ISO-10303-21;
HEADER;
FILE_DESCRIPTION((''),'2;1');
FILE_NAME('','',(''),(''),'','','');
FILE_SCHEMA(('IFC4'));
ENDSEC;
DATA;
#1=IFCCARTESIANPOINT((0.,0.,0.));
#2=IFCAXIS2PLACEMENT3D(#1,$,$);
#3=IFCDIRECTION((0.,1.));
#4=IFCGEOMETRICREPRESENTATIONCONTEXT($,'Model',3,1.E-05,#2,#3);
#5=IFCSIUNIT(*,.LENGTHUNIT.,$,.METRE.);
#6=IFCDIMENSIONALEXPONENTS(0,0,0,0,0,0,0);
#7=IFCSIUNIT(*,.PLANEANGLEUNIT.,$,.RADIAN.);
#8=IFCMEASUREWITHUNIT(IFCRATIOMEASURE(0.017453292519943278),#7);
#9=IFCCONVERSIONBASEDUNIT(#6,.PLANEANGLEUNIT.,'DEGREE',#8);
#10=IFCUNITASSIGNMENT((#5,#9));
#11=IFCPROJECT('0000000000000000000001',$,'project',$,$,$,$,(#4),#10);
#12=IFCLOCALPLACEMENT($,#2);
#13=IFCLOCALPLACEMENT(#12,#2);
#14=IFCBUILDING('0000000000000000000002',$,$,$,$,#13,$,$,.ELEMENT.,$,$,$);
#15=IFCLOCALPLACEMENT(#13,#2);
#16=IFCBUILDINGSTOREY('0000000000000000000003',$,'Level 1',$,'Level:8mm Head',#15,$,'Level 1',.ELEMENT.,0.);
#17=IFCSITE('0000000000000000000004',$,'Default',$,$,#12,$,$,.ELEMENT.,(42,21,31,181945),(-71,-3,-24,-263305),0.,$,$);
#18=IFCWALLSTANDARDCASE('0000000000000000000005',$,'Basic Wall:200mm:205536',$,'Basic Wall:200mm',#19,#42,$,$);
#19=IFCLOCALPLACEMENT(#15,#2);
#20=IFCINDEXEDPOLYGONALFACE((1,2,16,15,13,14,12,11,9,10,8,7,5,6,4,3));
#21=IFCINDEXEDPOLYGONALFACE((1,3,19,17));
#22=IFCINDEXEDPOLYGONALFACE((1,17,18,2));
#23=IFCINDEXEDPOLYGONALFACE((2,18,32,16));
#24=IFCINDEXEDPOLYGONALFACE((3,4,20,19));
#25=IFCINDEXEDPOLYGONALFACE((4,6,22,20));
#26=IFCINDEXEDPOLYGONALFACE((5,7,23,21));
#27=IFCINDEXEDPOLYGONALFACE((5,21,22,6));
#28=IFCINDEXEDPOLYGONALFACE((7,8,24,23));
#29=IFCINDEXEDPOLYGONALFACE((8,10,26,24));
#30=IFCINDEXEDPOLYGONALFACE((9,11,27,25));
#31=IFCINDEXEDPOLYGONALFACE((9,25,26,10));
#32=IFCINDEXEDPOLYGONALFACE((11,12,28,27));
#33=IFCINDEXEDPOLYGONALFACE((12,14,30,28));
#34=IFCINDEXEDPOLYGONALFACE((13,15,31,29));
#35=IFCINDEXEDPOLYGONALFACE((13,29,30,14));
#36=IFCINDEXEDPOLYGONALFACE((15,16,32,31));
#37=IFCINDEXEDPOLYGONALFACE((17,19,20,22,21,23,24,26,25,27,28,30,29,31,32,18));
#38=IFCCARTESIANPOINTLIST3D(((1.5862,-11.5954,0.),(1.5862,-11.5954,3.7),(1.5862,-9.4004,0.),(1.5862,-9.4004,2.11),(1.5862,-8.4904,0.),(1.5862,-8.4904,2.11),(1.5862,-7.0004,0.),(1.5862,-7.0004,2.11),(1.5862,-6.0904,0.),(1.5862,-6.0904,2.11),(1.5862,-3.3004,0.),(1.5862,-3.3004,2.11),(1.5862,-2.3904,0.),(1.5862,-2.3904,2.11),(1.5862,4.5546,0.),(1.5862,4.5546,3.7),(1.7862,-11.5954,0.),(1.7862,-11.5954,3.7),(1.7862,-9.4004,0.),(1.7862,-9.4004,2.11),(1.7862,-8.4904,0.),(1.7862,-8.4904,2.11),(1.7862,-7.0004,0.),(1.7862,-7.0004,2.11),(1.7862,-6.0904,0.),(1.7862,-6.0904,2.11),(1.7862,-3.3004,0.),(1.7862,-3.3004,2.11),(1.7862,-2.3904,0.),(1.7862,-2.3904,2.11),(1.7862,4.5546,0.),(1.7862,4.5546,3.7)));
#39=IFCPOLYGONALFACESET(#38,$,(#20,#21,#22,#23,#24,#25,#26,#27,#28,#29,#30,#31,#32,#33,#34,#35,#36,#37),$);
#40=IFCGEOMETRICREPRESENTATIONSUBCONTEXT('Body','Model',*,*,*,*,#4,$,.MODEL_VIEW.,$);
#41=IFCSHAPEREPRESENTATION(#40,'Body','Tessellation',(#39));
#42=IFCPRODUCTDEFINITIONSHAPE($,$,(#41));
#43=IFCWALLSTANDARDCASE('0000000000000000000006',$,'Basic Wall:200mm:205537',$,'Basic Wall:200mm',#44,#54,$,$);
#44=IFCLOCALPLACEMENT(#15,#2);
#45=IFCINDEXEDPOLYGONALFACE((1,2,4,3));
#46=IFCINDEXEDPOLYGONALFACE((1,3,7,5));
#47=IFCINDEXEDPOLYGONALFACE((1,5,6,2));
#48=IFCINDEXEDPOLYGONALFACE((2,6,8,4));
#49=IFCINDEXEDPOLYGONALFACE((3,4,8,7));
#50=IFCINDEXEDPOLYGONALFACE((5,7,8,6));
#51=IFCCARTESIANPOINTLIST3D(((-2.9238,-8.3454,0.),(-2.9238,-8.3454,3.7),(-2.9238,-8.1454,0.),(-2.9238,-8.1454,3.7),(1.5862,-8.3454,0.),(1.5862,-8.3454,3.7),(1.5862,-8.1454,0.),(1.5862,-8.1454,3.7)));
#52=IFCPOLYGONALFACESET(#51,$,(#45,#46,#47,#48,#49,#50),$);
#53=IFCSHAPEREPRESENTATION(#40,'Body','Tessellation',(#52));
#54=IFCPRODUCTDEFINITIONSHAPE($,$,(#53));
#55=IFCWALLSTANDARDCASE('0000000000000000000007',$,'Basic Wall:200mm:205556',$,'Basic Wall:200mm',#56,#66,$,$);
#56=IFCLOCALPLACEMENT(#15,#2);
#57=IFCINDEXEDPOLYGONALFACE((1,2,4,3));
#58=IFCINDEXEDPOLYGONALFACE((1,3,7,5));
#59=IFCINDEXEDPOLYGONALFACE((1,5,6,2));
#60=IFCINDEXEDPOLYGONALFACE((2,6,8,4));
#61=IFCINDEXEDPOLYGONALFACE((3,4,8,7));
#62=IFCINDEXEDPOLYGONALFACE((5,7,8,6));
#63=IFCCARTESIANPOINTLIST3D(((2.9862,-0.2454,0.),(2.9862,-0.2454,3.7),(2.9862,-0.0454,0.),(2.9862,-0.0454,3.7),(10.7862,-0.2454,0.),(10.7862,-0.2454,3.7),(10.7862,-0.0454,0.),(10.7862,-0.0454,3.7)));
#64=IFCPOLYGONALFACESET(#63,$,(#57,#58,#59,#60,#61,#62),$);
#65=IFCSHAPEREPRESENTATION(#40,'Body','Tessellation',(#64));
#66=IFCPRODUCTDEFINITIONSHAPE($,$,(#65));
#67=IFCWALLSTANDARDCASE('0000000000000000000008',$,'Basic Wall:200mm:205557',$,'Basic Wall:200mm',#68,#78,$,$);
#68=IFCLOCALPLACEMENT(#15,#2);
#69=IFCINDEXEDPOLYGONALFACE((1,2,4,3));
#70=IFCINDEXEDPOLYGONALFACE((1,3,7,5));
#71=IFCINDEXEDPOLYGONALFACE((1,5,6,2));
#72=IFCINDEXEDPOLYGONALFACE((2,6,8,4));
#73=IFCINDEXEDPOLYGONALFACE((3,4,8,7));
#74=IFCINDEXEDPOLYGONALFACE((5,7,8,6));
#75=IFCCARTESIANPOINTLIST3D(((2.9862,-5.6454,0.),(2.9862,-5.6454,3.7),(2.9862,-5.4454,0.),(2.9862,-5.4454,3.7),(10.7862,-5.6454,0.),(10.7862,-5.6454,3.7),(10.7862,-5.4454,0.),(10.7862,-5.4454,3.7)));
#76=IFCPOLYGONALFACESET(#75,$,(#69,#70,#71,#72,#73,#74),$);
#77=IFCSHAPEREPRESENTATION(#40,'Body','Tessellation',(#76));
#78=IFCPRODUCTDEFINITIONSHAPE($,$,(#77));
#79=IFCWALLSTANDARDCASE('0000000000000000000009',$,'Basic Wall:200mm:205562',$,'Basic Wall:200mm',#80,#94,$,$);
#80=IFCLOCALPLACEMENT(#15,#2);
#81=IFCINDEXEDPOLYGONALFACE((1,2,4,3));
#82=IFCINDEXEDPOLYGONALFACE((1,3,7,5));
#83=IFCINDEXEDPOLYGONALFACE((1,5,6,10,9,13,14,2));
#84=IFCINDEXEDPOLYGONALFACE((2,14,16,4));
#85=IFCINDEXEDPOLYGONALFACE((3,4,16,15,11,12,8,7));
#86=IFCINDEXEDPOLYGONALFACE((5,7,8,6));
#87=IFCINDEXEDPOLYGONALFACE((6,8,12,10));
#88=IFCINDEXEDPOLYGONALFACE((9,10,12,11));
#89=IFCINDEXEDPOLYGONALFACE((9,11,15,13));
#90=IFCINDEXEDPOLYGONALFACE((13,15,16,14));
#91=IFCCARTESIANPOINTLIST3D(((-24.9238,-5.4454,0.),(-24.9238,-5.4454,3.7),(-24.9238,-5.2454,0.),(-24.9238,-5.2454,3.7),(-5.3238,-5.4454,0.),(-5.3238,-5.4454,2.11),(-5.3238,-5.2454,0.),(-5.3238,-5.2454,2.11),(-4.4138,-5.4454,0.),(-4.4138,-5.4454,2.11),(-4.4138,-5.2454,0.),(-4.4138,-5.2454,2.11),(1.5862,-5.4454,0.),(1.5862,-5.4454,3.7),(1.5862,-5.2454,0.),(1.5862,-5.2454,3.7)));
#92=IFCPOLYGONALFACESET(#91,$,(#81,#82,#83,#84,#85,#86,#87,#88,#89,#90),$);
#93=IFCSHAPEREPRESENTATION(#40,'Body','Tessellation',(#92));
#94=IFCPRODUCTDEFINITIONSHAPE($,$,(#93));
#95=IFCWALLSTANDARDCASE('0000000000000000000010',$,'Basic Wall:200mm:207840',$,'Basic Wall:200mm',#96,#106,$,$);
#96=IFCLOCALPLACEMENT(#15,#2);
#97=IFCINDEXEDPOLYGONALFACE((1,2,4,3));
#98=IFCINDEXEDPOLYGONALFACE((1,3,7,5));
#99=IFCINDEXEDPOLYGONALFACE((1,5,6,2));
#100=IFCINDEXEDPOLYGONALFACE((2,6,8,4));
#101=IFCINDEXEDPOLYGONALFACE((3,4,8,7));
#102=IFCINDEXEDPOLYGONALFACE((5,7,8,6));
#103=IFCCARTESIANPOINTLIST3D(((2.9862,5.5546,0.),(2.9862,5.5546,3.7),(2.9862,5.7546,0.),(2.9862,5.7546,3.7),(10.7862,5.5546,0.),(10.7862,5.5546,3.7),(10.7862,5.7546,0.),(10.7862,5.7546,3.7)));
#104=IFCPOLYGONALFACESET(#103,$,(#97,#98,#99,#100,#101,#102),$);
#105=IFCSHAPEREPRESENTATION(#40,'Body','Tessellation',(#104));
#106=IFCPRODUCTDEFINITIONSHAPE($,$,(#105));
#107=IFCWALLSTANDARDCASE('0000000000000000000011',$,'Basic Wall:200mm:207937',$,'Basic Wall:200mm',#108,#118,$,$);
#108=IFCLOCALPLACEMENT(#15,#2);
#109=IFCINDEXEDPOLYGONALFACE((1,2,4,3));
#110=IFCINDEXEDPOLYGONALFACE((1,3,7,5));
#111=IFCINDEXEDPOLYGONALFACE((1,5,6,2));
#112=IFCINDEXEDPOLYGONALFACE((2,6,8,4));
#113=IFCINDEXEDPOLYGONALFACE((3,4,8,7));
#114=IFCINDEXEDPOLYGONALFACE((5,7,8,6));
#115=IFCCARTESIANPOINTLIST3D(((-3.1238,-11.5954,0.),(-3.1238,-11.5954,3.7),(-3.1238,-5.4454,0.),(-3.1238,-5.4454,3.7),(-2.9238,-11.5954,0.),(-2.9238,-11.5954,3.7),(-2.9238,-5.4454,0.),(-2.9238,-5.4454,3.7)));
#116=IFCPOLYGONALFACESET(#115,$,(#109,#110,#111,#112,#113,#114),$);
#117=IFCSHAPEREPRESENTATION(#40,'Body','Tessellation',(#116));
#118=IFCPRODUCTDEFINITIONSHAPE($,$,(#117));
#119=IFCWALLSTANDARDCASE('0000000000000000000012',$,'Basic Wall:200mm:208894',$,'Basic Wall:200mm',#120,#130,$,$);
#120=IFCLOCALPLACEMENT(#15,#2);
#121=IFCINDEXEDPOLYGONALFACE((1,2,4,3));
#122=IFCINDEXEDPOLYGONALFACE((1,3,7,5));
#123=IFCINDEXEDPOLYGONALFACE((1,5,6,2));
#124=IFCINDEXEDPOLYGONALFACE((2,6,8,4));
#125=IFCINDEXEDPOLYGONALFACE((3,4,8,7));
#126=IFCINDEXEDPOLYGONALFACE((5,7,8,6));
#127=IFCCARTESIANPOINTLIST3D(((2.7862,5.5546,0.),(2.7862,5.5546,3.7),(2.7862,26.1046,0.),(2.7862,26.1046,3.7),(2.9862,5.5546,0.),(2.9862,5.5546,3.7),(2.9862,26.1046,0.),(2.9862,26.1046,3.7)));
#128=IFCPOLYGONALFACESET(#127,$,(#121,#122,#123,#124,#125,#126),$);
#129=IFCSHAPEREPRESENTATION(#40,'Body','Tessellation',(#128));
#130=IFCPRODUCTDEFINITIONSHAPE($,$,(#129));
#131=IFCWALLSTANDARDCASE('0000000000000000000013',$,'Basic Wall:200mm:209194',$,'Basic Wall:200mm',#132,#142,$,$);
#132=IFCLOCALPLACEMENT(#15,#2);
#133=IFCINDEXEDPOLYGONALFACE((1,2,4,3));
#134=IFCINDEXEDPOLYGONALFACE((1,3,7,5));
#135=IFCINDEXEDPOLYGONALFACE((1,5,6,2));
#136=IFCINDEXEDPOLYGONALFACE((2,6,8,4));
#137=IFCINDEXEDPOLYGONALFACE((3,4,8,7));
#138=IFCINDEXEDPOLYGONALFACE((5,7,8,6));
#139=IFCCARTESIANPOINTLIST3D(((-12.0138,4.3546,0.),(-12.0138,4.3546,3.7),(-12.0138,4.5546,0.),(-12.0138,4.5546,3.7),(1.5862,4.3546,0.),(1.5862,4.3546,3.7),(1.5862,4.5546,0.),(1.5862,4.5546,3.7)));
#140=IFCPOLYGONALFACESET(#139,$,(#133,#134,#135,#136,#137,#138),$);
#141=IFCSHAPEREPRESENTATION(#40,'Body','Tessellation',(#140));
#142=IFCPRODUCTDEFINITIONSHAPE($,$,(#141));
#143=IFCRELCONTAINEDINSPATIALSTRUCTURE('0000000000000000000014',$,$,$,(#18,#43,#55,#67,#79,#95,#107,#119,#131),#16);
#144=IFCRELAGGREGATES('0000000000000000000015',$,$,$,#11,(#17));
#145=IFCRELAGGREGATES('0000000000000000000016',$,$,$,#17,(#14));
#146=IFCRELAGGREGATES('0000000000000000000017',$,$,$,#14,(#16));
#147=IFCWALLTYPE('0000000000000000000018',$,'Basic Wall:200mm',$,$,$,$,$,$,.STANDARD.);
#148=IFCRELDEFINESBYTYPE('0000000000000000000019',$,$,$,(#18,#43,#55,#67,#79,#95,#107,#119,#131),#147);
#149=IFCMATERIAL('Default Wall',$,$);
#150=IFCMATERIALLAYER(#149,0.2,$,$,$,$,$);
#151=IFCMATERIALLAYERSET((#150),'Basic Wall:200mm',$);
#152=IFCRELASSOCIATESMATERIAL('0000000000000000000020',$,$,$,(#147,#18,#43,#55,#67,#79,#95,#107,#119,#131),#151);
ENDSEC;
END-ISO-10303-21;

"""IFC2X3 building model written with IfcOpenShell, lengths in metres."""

from ifc_helpers import new_model, entity, si_unit, converted_unit, direction, frame, frame_2d, origin, place, context, subcontext, project, spatial, polyline, rectangle, extrude, clip, bounded_halfspace, material, layer, layer_set, layer_usage, type_object, element, save


model = new_model("IFC2X3")

# Units and contexts
model_context = context("Model", 3, precision=1e-05, world=origin(), true_north=direction((0.0, 1.0)))
body_context = subcontext(model_context, "Body", "Model", "MODEL_VIEW")
ifc_project = project(units=[si_unit("LENGTHUNIT", "METRE"), converted_unit("PLANEANGLEUNIT", "DEGREE", entity("IfcRatioMeasure", 0.017453292519943278), si_unit("PLANEANGLEUNIT", "RADIAN"), dimensions=[0, 0, 0, 0, 0, 0, 0])], contexts=[model_context])

# Site, building, storey
site_placement = place(None, origin())
site = spatial("IfcSite", under=ifc_project, at=site_placement, Name="Default", CompositionType="ELEMENT", RefLatitude=(42, 21, 31, 181945), RefLongitude=(-71, -3, -24, -263305), RefElevation=0.0)
building_placement = place(site_placement, origin())
building = spatial("IfcBuilding", under=site, at=building_placement, CompositionType="ELEMENT")
storey_placement = place(building_placement, origin())
storey = spatial("IfcBuildingStorey", under=building, at=storey_placement, Name="Level 1", ObjectType="Level:8mm Head", LongName="Level 1", CompositionType="ELEMENT", Elevation=0.0)

# Shared definitions
ifc_material_1 = material(Name="Default Wall")
ifc_layer_1 = layer(ifc_material_1, 0.2)
ifc_layer_set_1 = layer_set([ifc_layer_1], Name="Basic Wall:200mm")
wall_type_1 = type_object("IfcWallType", Name="Basic Wall:200mm", PredefinedType="STANDARD", material=ifc_layer_set_1)

# Wall, openings
ifc_layer_usage_1 = layer_usage(ifc_layer_set_1, "AXIS2", "NEGATIVE", 0.1)
wall_1_placement = place(storey_placement, frame((1.6862, -11.5954, 0.0), z_axis=(0.0, 0.0, 1.0), x_axis=(0.0, 1.0, 0.0)))
wall_1 = element("IfcWallStandardCase", 1, at=wall_1_placement, inside=storey, type_object=wall_type_1, material=ifc_layer_usage_1, Name="Basic Wall:200mm:205536", ObjectType="Basic Wall:200mm", context=body_context, shape_type="Clipping", body=[
    clip(extrude(rectangle(XDim=16.15, YDim=0.2, at=frame_2d((8.075, 0.0), x_axis=(-1.0, 0.0))), origin(), (0.0, 0.0, 1.0), 3.7), bounded_halfspace(frame((0.0, -0.1, 3.7), z_axis=(0.0, 0.0, -1.0), x_axis=(-1.0, 0.0, 0.0)), True, frame((0.0, -0.1, 3.7), z_axis=(0.0, 0.0, -1.0), x_axis=(-1.0, 0.0, 0.0)), polyline([(0.0, 0.0), (0.0, 0.2), (-15.95, 0.2), (-16.15, 0.2), (-16.15, 0.0), (0.0, 0.0)]))),
])
opening_1_placement = place(wall_1_placement, frame((3.105, 0.1, 0.0)))
element("IfcOpeningElement", 2, at=opening_1_placement, cuts=wall_1, ObjectType="Opening", context=body_context, shape_type="SweptSolid", body=[
    extrude(rectangle(XDim=2.11, YDim=0.91, at=frame_2d((1.055, 0.455), x_axis=(1.0, 0.0))), frame((0.0, 0.0, 0.0), z_axis=(0.0, -1.0, 0.0), x_axis=(0.0, 0.0, 1.0)), (0.0, 0.0, 1.0), 0.2),
])
opening_2_placement = place(wall_1_placement, frame((4.595, -0.1, 0.0)))
element("IfcOpeningElement", 3, at=opening_2_placement, cuts=wall_1, ObjectType="Opening", context=body_context, shape_type="SweptSolid", body=[
    extrude(rectangle(XDim=2.11, YDim=0.91, at=frame_2d((1.055, 0.455), x_axis=(1.0, 0.0))), frame((0.0, 0.0, 0.0), z_axis=(0.0, 1.0, 0.0), x_axis=(0.0, 0.0, 1.0)), (0.0, 0.0, 1.0), 0.2),
])
opening_3_placement = place(wall_1_placement, frame((8.295, -0.1, 0.0)))
element("IfcOpeningElement", 4, at=opening_3_placement, cuts=wall_1, ObjectType="Opening", context=body_context, shape_type="SweptSolid", body=[
    extrude(rectangle(XDim=2.11, YDim=0.91, at=frame_2d((1.055, 0.455), x_axis=(1.0, 0.0))), frame((0.0, 0.0, 0.0), z_axis=(0.0, 1.0, 0.0), x_axis=(0.0, 0.0, 1.0)), (0.0, 0.0, 1.0), 0.2),
])

# Walls
ifc_layer_usage_2 = layer_usage(ifc_layer_set_1, "AXIS2", "NEGATIVE", 0.1)
wall_2_placement = place(storey_placement, frame((1.5862, -8.2454, 0.0), z_axis=(0.0, 0.0, 1.0), x_axis=(-1.0, 0.0, 0.0)))
element("IfcWallStandardCase", 5, at=wall_2_placement, inside=storey, type_object=wall_type_1, material=ifc_layer_usage_2, Name="Basic Wall:200mm:205537", ObjectType="Basic Wall:200mm", context=body_context, shape_type="Clipping", body=[
    clip(extrude(rectangle(XDim=4.51, YDim=0.2, at=frame_2d((2.255, 0.0), x_axis=(-1.0, 0.0))), origin(), (0.0, 0.0, 1.0), 3.7), bounded_halfspace(frame((0.0, -0.1, 3.7), z_axis=(0.0, 0.0, -1.0), x_axis=(0.0, 1.0, 0.0)), True, frame((0.0, -0.1, 3.7), z_axis=(0.0, 0.0, -1.0), x_axis=(0.0, 1.0, 0.0)), polyline([(0.0, 0.0), (0.2, 0.0), (0.2, 4.51), (0.0, 4.51), (0.0, 0.0)]))),
])
ifc_layer_usage_3 = layer_usage(ifc_layer_set_1, "AXIS2", "NEGATIVE", 0.1)
wall_3_placement = place(storey_placement, frame((2.9862, -0.1454, 0.0)))
element("IfcWallStandardCase", 6, at=wall_3_placement, inside=storey, type_object=wall_type_1, material=ifc_layer_usage_3, Name="Basic Wall:200mm:205556", ObjectType="Basic Wall:200mm", context=body_context, shape_type="Clipping", body=[
    clip(extrude(rectangle(XDim=7.8, YDim=0.2, at=frame_2d((3.9, 0.0), x_axis=(-1.0, 0.0))), origin(), (0.0, 0.0, 1.0), 3.7), bounded_halfspace(frame((0.0, -0.1, 3.7), z_axis=(0.0, 0.0, -1.0), x_axis=(0.0, -1.0, 0.0)), True, frame((0.0, -0.1, 3.7), z_axis=(0.0, 0.0, -1.0), x_axis=(0.0, -1.0, 0.0)), polyline([(0.0, 0.0), (-0.2, 0.0), (-0.2, -7.8), (0.0, -7.8), (0.0, 0.0)]))),
])
ifc_layer_usage_4 = layer_usage(ifc_layer_set_1, "AXIS2", "NEGATIVE", 0.1)
wall_4_placement = place(storey_placement, frame((2.9862, -5.5454, 0.0)))
element("IfcWallStandardCase", 7, at=wall_4_placement, inside=storey, type_object=wall_type_1, material=ifc_layer_usage_4, Name="Basic Wall:200mm:205557", ObjectType="Basic Wall:200mm", context=body_context, shape_type="Clipping", body=[
    clip(extrude(rectangle(XDim=7.8, YDim=0.2, at=frame_2d((3.9, 0.0), x_axis=(-1.0, 0.0))), origin(), (0.0, 0.0, 1.0), 3.7), bounded_halfspace(frame((0.0, -0.1, 3.7), z_axis=(0.0, 0.0, -1.0), x_axis=(0.0, -1.0, 0.0)), True, frame((0.0, -0.1, 3.7), z_axis=(0.0, 0.0, -1.0), x_axis=(0.0, -1.0, 0.0)), polyline([(0.0, 0.0), (-0.2, 0.0), (-0.2, -7.8), (0.0, -7.8), (0.0, 0.0)]))),
])

# Wall, opening
ifc_layer_usage_5 = layer_usage(ifc_layer_set_1, "AXIS2", "NEGATIVE", 0.1)
wall_5_placement = place(storey_placement, frame((1.5862, -5.3454, 0.0), z_axis=(0.0, 0.0, 1.0), x_axis=(-1.0, 0.0, 0.0)))
wall_5 = element("IfcWallStandardCase", 8, at=wall_5_placement, inside=storey, type_object=wall_type_1, material=ifc_layer_usage_5, Name="Basic Wall:200mm:205562", ObjectType="Basic Wall:200mm", context=body_context, shape_type="Clipping", body=[
    clip(extrude(rectangle(XDim=0.2, YDim=26.51, at=frame_2d((13.255, 0.0), x_axis=(0.0, 1.0))), origin(), (0.0, 0.0, 1.0), 3.7), bounded_halfspace(frame((0.0, -0.1, 3.7), z_axis=(0.0, 0.0, -1.0), x_axis=(0.0, 1.0, 0.0)), True, frame((0.0, -0.1, 3.7), z_axis=(0.0, 0.0, -1.0), x_axis=(0.0, 1.0, 0.0)), polyline([(0.0, 0.0), (0.2, 0.0), (0.2, 4.51), (0.2, 4.71), (0.2, 26.51), (0.0, 26.51), (0.0, 0.0)]))),
])
opening_4_placement = place(wall_5_placement, frame((6.0, -0.1, 0.0)))
element("IfcOpeningElement", 9, at=opening_4_placement, cuts=wall_5, ObjectType="Opening", context=body_context, shape_type="SweptSolid", body=[
    extrude(rectangle(XDim=2.11, YDim=0.91, at=frame_2d((1.055, 0.455), x_axis=(1.0, 0.0))), frame((0.0, 0.0, 0.0), z_axis=(0.0, 1.0, 0.0), x_axis=(0.0, 0.0, 1.0)), (0.0, 0.0, 1.0), 0.2),
])

# Walls
ifc_layer_usage_6 = layer_usage(ifc_layer_set_1, "AXIS2", "NEGATIVE", 0.1)
wall_6_placement = place(storey_placement, frame((2.9862, 5.6546, 0.0)))
element("IfcWallStandardCase", 10, at=wall_6_placement, inside=storey, type_object=wall_type_1, material=ifc_layer_usage_6, Name="Basic Wall:200mm:207840", ObjectType="Basic Wall:200mm", context=body_context, shape_type="Clipping", body=[
    clip(extrude(rectangle(XDim=7.8, YDim=0.2, at=frame_2d((3.9, 0.0), x_axis=(-1.0, 0.0))), origin(), (0.0, 0.0, 1.0), 3.7), bounded_halfspace(frame((0.0, -0.1, 3.7), z_axis=(0.0, 0.0, -1.0), x_axis=(0.0, -1.0, 0.0)), True, frame((0.0, -0.1, 3.7), z_axis=(0.0, 0.0, -1.0), x_axis=(0.0, -1.0, 0.0)), polyline([(0.0, 0.0), (-0.2, 0.0), (-0.2, -7.8), (0.0, -7.8), (0.0, 0.0)]))),
])
ifc_layer_usage_7 = layer_usage(ifc_layer_set_1, "AXIS2", "NEGATIVE", 0.1)
wall_7_placement = place(storey_placement, frame((-3.0238, -5.4454, 0.0), z_axis=(0.0, 0.0, 1.0), x_axis=(0.0, -1.0, 0.0)))
element("IfcWallStandardCase", 11, at=wall_7_placement, inside=storey, type_object=wall_type_1, material=ifc_layer_usage_7, Name="Basic Wall:200mm:207937", ObjectType="Basic Wall:200mm", context=body_context, shape_type="Clipping", body=[
    clip(extrude(rectangle(XDim=6.15, YDim=0.2, at=frame_2d((3.075, 0.0), x_axis=(-1.0, 0.0))), origin(), (0.0, 0.0, 1.0), 3.7), bounded_halfspace(frame((0.0, -0.1, 3.7), z_axis=(0.0, 0.0, -1.0), x_axis=(1.0, 0.0, 0.0)), True, frame((0.0, -0.1, 3.7), z_axis=(0.0, 0.0, -1.0), x_axis=(1.0, 0.0, 0.0)), polyline([(0.0, 0.0), (0.0, -0.2), (2.7, -0.2), (2.9, -0.2), (6.15, -0.2), (6.15, 0.0), (0.0, 0.0)]))),
])
ifc_layer_usage_8 = layer_usage(ifc_layer_set_1, "AXIS2", "NEGATIVE", 0.1)
wall_8_placement = place(storey_placement, frame((2.8862, 5.5546, 0.0), z_axis=(0.0, 0.0, 1.0), x_axis=(0.0, 1.0, 0.0)))
element("IfcWallStandardCase", 12, at=wall_8_placement, inside=storey, type_object=wall_type_1, material=ifc_layer_usage_8, Name="Basic Wall:200mm:208894", ObjectType="Basic Wall:200mm", context=body_context, shape_type="Clipping", body=[
    clip(extrude(rectangle(XDim=20.55, YDim=0.2, at=frame_2d((10.275, 0.0), x_axis=(-1.0, 0.0))), origin(), (0.0, 0.0, 1.0), 3.7), bounded_halfspace(frame((0.0, -0.1, 3.7), z_axis=(0.0, 0.0, -1.0), x_axis=(-1.0, 0.0, 0.0)), True, frame((0.0, -0.1, 3.7), z_axis=(0.0, 0.0, -1.0), x_axis=(-1.0, 0.0, 0.0)), polyline([(0.0, 0.0), (0.0, 0.2), (-20.55, 0.2), (-20.55, 0.0), (-0.2, 0.0), (0.0, 0.0)]))),
])
ifc_layer_usage_9 = layer_usage(ifc_layer_set_1, "AXIS2", "NEGATIVE", 0.1)
wall_9_placement = place(storey_placement, frame((1.5862, 4.4546, 0.0), z_axis=(0.0, 0.0, 1.0), x_axis=(-1.0, 0.0, 0.0)))
element("IfcWallStandardCase", 13, at=wall_9_placement, inside=storey, type_object=wall_type_1, material=ifc_layer_usage_9, Name="Basic Wall:200mm:209194", ObjectType="Basic Wall:200mm", context=body_context, shape_type="Clipping", body=[
    clip(extrude(rectangle(XDim=13.6, YDim=0.2, at=frame_2d((6.8, 0.0), x_axis=(-1.0, 0.0))), origin(), (0.0, 0.0, 1.0), 3.7), bounded_halfspace(frame((0.0, -0.1, 3.7), z_axis=(0.0, 0.0, -1.0), x_axis=(0.0, 1.0, 0.0)), True, frame((0.0, -0.1, 3.7), z_axis=(0.0, 0.0, -1.0), x_axis=(0.0, 1.0, 0.0)), polyline([(0.0, 0.0), (0.2, 0.0), (0.2, 13.6), (0.0, 13.6), (0.0, 0.0)]))),
])

save(model, "model.ifc")
